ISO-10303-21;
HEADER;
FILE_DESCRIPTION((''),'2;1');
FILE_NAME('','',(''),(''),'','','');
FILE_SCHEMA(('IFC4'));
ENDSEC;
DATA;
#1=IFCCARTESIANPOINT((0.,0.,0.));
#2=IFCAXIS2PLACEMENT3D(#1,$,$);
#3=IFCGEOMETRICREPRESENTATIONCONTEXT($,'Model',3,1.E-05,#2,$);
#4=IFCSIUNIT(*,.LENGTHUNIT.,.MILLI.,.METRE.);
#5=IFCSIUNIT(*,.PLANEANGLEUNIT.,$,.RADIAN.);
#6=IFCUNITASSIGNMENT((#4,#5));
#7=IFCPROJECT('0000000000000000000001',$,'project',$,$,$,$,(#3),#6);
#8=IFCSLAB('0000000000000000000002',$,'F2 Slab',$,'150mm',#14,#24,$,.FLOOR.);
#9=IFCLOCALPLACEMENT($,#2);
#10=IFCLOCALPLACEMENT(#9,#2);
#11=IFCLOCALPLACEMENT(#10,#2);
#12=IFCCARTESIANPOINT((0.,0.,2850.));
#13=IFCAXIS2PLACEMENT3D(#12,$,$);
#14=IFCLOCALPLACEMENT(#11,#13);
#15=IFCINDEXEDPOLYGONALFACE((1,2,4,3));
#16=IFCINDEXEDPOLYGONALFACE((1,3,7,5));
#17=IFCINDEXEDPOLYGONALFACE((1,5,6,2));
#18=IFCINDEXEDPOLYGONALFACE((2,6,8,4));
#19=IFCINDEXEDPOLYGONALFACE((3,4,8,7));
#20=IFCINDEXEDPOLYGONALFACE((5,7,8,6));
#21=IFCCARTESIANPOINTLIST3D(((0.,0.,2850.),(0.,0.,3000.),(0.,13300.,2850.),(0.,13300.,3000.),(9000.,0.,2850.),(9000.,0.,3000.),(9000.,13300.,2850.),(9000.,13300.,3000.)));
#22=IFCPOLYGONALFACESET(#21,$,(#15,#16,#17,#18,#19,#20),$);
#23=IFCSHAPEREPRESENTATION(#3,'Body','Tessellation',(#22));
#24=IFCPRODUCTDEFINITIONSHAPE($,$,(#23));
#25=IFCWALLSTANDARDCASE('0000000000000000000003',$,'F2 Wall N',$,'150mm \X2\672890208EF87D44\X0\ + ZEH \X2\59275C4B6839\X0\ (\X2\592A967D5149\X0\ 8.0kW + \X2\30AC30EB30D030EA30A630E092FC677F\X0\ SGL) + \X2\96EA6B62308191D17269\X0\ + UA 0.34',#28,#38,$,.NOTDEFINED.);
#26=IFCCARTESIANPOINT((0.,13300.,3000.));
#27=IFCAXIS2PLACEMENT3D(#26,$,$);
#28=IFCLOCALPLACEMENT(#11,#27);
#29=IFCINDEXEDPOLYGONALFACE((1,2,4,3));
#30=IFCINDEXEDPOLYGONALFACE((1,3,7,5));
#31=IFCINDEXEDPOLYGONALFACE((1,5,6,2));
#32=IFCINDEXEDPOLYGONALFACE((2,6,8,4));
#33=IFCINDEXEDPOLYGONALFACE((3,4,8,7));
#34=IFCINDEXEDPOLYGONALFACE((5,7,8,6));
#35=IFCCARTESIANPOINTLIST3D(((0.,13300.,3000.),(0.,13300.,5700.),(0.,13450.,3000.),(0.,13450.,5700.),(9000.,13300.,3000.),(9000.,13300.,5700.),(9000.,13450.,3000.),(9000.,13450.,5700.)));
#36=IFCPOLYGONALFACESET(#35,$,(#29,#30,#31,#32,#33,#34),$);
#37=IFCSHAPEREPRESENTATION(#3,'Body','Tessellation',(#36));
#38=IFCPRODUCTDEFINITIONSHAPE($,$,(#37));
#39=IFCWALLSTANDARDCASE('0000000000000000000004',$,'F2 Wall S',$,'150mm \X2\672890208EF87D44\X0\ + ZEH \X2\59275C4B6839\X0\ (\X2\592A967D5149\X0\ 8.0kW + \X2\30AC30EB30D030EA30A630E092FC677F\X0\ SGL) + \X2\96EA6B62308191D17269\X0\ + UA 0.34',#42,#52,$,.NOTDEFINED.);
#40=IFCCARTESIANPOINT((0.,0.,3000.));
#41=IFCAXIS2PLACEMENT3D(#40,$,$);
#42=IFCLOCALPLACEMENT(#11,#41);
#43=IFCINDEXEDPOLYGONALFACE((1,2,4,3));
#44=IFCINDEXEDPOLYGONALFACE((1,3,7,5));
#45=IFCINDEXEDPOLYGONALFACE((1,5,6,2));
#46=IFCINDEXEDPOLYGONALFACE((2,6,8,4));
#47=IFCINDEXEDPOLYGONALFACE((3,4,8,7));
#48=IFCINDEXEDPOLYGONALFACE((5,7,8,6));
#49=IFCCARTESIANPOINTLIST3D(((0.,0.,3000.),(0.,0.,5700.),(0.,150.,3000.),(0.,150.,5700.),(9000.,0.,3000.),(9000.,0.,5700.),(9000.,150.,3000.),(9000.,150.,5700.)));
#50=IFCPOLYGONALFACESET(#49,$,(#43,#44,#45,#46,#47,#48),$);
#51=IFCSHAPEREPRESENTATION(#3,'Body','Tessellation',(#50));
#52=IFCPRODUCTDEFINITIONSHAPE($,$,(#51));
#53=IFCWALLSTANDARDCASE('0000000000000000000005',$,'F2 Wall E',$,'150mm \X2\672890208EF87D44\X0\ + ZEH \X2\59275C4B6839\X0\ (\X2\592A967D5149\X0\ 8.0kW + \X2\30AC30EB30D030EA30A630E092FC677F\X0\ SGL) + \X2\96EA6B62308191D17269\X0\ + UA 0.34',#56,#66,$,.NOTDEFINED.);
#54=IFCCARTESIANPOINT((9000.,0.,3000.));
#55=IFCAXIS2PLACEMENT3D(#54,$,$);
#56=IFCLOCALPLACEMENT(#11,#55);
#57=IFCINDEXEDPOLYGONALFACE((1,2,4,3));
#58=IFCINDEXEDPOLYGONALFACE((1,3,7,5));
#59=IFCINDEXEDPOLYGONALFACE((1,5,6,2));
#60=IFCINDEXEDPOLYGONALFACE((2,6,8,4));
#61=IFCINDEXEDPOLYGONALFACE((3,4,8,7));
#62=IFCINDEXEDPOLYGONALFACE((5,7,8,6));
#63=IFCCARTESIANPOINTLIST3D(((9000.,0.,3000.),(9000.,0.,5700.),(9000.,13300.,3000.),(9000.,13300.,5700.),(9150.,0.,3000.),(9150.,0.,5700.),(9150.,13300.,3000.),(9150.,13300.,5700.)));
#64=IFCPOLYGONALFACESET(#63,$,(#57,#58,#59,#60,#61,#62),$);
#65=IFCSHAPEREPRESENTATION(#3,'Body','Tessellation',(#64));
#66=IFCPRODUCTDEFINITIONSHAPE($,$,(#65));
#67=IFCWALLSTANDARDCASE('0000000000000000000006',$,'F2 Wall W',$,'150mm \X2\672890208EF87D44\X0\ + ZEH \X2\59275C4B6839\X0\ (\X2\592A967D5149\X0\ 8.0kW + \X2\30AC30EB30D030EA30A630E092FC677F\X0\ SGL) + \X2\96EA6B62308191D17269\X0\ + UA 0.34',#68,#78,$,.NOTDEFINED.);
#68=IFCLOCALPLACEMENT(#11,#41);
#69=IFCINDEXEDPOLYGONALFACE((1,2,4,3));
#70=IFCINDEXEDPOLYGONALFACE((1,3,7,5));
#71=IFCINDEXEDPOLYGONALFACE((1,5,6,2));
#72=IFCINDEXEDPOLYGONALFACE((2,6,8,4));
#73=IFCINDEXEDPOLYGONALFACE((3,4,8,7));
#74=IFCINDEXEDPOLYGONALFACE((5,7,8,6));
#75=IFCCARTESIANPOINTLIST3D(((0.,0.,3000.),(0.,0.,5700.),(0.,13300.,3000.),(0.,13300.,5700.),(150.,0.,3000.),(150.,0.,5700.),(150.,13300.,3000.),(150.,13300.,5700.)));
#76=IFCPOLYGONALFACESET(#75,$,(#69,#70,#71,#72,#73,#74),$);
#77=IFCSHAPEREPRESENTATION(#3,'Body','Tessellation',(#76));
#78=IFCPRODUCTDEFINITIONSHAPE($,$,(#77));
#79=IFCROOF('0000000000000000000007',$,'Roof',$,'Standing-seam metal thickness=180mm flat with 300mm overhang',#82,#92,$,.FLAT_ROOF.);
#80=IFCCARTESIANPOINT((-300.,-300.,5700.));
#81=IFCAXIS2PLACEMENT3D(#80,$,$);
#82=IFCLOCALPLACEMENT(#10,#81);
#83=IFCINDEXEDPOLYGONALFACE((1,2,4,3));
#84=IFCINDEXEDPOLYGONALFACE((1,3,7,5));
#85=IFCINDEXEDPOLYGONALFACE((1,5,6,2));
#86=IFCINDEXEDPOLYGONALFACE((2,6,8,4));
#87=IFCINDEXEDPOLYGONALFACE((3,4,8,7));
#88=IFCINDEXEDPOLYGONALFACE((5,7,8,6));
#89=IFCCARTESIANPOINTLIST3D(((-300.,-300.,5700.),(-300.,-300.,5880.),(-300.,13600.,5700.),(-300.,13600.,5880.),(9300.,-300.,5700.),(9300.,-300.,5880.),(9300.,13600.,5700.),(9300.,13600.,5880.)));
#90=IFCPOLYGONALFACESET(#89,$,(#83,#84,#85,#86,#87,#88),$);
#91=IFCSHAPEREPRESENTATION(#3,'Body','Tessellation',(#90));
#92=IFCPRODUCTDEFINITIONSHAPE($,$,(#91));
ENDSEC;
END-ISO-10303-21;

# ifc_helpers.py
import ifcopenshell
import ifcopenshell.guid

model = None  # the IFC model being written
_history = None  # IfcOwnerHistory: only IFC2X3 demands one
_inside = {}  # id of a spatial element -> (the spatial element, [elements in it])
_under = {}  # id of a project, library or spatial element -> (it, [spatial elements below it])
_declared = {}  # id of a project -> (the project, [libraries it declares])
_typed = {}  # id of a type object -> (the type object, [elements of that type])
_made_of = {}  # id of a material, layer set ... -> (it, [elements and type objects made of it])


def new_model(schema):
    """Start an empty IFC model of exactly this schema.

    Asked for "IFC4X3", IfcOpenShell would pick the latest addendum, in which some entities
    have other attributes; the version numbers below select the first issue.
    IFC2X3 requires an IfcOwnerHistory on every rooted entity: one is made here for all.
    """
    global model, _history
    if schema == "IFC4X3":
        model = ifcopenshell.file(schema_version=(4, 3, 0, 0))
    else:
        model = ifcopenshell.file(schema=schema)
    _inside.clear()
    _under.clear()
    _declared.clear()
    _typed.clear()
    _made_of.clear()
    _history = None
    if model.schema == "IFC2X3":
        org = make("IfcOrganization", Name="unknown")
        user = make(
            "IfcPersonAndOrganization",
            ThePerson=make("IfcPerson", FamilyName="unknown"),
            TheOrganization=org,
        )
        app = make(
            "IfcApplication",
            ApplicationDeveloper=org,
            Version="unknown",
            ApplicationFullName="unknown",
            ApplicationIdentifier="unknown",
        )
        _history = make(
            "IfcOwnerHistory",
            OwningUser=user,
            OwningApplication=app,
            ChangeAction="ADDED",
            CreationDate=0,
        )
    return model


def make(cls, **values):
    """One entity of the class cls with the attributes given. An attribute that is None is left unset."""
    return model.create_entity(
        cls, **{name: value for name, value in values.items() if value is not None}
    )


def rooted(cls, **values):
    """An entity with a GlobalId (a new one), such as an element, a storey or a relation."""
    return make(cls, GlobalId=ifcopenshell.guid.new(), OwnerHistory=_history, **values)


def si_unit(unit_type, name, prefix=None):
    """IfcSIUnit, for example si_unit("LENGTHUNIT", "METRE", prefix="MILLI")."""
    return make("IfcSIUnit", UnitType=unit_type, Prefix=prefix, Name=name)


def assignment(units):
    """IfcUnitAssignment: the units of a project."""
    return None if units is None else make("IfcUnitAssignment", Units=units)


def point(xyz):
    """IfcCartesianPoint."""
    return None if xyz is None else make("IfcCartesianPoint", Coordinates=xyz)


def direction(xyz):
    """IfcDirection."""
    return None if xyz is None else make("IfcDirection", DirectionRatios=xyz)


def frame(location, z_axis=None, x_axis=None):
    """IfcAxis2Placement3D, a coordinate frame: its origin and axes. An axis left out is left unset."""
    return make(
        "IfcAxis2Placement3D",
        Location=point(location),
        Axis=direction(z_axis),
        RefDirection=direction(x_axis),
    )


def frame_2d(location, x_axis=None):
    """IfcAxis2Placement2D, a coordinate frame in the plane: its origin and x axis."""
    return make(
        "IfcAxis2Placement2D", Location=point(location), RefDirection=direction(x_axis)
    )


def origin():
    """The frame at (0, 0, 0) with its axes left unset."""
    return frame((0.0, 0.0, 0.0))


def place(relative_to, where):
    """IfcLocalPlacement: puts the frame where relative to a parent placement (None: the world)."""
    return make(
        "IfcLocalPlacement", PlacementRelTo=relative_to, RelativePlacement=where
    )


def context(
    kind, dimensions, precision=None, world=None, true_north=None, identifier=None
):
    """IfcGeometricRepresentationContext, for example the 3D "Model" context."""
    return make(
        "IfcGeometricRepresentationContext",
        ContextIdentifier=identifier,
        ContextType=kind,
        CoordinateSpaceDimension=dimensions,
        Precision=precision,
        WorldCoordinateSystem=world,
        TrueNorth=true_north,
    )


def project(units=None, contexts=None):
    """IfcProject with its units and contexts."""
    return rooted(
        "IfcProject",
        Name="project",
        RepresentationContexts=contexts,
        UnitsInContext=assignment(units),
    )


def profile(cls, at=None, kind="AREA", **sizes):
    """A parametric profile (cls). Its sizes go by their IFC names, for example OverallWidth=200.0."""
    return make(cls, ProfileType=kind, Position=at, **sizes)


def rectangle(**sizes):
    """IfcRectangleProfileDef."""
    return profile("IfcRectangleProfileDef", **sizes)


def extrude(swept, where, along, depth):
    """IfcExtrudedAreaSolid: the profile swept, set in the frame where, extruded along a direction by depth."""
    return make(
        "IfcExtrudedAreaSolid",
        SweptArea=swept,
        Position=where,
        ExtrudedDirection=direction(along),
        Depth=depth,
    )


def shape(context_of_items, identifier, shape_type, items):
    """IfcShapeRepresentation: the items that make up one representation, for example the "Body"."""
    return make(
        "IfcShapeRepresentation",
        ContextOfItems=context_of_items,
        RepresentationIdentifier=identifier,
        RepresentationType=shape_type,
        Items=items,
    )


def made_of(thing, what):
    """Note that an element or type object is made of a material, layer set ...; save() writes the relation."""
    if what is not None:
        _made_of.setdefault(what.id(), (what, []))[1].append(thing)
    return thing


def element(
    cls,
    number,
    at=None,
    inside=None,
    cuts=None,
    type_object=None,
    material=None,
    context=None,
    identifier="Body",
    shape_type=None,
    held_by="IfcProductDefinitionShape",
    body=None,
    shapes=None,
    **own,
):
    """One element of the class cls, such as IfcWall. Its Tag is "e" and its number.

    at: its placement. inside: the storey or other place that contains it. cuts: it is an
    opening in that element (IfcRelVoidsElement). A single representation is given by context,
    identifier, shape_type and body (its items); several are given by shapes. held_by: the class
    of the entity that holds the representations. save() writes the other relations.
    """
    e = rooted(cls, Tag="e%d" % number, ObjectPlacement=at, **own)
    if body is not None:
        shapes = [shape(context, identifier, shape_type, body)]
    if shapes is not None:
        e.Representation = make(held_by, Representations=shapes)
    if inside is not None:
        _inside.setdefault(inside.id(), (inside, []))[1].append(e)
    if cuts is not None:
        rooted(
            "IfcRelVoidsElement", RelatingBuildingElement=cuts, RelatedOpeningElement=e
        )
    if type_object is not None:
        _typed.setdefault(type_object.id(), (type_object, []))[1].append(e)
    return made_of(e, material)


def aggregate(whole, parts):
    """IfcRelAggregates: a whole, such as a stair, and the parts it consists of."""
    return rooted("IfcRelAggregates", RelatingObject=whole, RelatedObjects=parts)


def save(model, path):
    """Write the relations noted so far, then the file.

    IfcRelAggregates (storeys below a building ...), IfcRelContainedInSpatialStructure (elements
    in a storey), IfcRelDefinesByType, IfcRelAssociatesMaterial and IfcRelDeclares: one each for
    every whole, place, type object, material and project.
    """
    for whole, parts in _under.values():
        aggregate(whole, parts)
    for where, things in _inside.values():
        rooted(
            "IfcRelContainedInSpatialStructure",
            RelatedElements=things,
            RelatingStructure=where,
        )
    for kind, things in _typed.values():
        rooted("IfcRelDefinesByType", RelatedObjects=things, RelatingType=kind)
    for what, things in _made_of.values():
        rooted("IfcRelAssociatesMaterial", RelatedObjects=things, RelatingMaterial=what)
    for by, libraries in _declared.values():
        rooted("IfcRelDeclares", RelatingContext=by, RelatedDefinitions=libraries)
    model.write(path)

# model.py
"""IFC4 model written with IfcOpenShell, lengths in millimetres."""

from ifc_helpers import new_model, si_unit, frame, frame_2d, origin, place, context, project, rectangle, extrude, element, save


model = new_model("IFC4")

# Units and contexts
model_context = context("Model", 3, precision=1e-05, world=origin())
ifc_project = project(units=[si_unit("LENGTHUNIT", "METRE", prefix="MILLI"), si_unit("PLANEANGLEUNIT", "RADIAN")], contexts=[model_context])

# Slab
placement_1 = place(None, origin())
placement_2 = place(placement_1, origin())
placement_3 = place(placement_2, origin())
slab_placement = place(placement_3, frame((0.0, 0.0, 2850.0)))
element("IfcSlab", 1, at=slab_placement, Name="F2 Slab", ObjectType="150mm", PredefinedType="FLOOR", context=model_context, shape_type="SweptSolid", body=[
    extrude(rectangle(XDim=9000.0, YDim=13300.0, at=frame_2d((4500.0, 6650.0))), frame((0.0, 0.0, 2850.0)), (0.0, 0.0, 1.0), 150.0),
])

# Walls
wall_1_placement = place(placement_3, frame((0.0, 13300.0, 3000.0)))
element("IfcWallStandardCase", 2, at=wall_1_placement, Name="F2 Wall N", ObjectType="150mm 木造軸組 + ZEH 大屋根 (太陽光 8.0kW + ガルバリウム鋼板 SGL) + 雪止め金物 + UA 0.34", PredefinedType="NOTDEFINED", context=model_context, shape_type="SweptSolid", body=[
    extrude(rectangle(XDim=9000.0, YDim=150.0, at=frame_2d((4500.0, 75.0))), frame((0.0, 13300.0, 3000.0)), (0.0, 0.0, 1.0), 2700.0),
])
wall_2_placement = place(placement_3, frame((0.0, 0.0, 3000.0)))
element("IfcWallStandardCase", 3, at=wall_2_placement, Name="F2 Wall S", ObjectType="150mm 木造軸組 + ZEH 大屋根 (太陽光 8.0kW + ガルバリウム鋼板 SGL) + 雪止め金物 + UA 0.34", PredefinedType="NOTDEFINED", context=model_context, shape_type="SweptSolid", body=[
    extrude(rectangle(XDim=9000.0, YDim=150.0, at=frame_2d((4500.0, 75.0))), frame((0.0, 0.0, 3000.0)), (0.0, 0.0, 1.0), 2700.0),
])
wall_3_placement = place(placement_3, frame((9000.0, 0.0, 3000.0)))
element("IfcWallStandardCase", 4, at=wall_3_placement, Name="F2 Wall E", ObjectType="150mm 木造軸組 + ZEH 大屋根 (太陽光 8.0kW + ガルバリウム鋼板 SGL) + 雪止め金物 + UA 0.34", PredefinedType="NOTDEFINED", context=model_context, shape_type="SweptSolid", body=[
    extrude(rectangle(XDim=150.0, YDim=13300.0, at=frame_2d((75.0, 6650.0))), frame((9000.0, 0.0, 3000.0)), (0.0, 0.0, 1.0), 2700.0),
])
wall_4_placement = place(placement_3, frame((0.0, 0.0, 3000.0)))
element("IfcWallStandardCase", 5, at=wall_4_placement, Name="F2 Wall W", ObjectType="150mm 木造軸組 + ZEH 大屋根 (太陽光 8.0kW + ガルバリウム鋼板 SGL) + 雪止め金物 + UA 0.34", PredefinedType="NOTDEFINED", context=model_context, shape_type="SweptSolid", body=[
    extrude(rectangle(XDim=150.0, YDim=13300.0, at=frame_2d((75.0, 6650.0))), frame((0.0, 0.0, 3000.0)), (0.0, 0.0, 1.0), 2700.0),
])

# Roof
roof_placement = place(placement_2, frame((-300.0, -300.0, 5700.0)))
element("IfcRoof", 6, at=roof_placement, Name="Roof", ObjectType="Standing-seam metal thickness=180mm flat with 300mm overhang", PredefinedType="FLAT_ROOF", context=model_context, shape_type="SweptSolid", body=[
    extrude(rectangle(XDim=9600.0, YDim=13900.0, at=frame_2d((4800.0, 6950.0))), frame((-300.0, -300.0, 5700.0)), (0.0, 0.0, 1.0), 180.0),
])

save(model, "model.ifc")
